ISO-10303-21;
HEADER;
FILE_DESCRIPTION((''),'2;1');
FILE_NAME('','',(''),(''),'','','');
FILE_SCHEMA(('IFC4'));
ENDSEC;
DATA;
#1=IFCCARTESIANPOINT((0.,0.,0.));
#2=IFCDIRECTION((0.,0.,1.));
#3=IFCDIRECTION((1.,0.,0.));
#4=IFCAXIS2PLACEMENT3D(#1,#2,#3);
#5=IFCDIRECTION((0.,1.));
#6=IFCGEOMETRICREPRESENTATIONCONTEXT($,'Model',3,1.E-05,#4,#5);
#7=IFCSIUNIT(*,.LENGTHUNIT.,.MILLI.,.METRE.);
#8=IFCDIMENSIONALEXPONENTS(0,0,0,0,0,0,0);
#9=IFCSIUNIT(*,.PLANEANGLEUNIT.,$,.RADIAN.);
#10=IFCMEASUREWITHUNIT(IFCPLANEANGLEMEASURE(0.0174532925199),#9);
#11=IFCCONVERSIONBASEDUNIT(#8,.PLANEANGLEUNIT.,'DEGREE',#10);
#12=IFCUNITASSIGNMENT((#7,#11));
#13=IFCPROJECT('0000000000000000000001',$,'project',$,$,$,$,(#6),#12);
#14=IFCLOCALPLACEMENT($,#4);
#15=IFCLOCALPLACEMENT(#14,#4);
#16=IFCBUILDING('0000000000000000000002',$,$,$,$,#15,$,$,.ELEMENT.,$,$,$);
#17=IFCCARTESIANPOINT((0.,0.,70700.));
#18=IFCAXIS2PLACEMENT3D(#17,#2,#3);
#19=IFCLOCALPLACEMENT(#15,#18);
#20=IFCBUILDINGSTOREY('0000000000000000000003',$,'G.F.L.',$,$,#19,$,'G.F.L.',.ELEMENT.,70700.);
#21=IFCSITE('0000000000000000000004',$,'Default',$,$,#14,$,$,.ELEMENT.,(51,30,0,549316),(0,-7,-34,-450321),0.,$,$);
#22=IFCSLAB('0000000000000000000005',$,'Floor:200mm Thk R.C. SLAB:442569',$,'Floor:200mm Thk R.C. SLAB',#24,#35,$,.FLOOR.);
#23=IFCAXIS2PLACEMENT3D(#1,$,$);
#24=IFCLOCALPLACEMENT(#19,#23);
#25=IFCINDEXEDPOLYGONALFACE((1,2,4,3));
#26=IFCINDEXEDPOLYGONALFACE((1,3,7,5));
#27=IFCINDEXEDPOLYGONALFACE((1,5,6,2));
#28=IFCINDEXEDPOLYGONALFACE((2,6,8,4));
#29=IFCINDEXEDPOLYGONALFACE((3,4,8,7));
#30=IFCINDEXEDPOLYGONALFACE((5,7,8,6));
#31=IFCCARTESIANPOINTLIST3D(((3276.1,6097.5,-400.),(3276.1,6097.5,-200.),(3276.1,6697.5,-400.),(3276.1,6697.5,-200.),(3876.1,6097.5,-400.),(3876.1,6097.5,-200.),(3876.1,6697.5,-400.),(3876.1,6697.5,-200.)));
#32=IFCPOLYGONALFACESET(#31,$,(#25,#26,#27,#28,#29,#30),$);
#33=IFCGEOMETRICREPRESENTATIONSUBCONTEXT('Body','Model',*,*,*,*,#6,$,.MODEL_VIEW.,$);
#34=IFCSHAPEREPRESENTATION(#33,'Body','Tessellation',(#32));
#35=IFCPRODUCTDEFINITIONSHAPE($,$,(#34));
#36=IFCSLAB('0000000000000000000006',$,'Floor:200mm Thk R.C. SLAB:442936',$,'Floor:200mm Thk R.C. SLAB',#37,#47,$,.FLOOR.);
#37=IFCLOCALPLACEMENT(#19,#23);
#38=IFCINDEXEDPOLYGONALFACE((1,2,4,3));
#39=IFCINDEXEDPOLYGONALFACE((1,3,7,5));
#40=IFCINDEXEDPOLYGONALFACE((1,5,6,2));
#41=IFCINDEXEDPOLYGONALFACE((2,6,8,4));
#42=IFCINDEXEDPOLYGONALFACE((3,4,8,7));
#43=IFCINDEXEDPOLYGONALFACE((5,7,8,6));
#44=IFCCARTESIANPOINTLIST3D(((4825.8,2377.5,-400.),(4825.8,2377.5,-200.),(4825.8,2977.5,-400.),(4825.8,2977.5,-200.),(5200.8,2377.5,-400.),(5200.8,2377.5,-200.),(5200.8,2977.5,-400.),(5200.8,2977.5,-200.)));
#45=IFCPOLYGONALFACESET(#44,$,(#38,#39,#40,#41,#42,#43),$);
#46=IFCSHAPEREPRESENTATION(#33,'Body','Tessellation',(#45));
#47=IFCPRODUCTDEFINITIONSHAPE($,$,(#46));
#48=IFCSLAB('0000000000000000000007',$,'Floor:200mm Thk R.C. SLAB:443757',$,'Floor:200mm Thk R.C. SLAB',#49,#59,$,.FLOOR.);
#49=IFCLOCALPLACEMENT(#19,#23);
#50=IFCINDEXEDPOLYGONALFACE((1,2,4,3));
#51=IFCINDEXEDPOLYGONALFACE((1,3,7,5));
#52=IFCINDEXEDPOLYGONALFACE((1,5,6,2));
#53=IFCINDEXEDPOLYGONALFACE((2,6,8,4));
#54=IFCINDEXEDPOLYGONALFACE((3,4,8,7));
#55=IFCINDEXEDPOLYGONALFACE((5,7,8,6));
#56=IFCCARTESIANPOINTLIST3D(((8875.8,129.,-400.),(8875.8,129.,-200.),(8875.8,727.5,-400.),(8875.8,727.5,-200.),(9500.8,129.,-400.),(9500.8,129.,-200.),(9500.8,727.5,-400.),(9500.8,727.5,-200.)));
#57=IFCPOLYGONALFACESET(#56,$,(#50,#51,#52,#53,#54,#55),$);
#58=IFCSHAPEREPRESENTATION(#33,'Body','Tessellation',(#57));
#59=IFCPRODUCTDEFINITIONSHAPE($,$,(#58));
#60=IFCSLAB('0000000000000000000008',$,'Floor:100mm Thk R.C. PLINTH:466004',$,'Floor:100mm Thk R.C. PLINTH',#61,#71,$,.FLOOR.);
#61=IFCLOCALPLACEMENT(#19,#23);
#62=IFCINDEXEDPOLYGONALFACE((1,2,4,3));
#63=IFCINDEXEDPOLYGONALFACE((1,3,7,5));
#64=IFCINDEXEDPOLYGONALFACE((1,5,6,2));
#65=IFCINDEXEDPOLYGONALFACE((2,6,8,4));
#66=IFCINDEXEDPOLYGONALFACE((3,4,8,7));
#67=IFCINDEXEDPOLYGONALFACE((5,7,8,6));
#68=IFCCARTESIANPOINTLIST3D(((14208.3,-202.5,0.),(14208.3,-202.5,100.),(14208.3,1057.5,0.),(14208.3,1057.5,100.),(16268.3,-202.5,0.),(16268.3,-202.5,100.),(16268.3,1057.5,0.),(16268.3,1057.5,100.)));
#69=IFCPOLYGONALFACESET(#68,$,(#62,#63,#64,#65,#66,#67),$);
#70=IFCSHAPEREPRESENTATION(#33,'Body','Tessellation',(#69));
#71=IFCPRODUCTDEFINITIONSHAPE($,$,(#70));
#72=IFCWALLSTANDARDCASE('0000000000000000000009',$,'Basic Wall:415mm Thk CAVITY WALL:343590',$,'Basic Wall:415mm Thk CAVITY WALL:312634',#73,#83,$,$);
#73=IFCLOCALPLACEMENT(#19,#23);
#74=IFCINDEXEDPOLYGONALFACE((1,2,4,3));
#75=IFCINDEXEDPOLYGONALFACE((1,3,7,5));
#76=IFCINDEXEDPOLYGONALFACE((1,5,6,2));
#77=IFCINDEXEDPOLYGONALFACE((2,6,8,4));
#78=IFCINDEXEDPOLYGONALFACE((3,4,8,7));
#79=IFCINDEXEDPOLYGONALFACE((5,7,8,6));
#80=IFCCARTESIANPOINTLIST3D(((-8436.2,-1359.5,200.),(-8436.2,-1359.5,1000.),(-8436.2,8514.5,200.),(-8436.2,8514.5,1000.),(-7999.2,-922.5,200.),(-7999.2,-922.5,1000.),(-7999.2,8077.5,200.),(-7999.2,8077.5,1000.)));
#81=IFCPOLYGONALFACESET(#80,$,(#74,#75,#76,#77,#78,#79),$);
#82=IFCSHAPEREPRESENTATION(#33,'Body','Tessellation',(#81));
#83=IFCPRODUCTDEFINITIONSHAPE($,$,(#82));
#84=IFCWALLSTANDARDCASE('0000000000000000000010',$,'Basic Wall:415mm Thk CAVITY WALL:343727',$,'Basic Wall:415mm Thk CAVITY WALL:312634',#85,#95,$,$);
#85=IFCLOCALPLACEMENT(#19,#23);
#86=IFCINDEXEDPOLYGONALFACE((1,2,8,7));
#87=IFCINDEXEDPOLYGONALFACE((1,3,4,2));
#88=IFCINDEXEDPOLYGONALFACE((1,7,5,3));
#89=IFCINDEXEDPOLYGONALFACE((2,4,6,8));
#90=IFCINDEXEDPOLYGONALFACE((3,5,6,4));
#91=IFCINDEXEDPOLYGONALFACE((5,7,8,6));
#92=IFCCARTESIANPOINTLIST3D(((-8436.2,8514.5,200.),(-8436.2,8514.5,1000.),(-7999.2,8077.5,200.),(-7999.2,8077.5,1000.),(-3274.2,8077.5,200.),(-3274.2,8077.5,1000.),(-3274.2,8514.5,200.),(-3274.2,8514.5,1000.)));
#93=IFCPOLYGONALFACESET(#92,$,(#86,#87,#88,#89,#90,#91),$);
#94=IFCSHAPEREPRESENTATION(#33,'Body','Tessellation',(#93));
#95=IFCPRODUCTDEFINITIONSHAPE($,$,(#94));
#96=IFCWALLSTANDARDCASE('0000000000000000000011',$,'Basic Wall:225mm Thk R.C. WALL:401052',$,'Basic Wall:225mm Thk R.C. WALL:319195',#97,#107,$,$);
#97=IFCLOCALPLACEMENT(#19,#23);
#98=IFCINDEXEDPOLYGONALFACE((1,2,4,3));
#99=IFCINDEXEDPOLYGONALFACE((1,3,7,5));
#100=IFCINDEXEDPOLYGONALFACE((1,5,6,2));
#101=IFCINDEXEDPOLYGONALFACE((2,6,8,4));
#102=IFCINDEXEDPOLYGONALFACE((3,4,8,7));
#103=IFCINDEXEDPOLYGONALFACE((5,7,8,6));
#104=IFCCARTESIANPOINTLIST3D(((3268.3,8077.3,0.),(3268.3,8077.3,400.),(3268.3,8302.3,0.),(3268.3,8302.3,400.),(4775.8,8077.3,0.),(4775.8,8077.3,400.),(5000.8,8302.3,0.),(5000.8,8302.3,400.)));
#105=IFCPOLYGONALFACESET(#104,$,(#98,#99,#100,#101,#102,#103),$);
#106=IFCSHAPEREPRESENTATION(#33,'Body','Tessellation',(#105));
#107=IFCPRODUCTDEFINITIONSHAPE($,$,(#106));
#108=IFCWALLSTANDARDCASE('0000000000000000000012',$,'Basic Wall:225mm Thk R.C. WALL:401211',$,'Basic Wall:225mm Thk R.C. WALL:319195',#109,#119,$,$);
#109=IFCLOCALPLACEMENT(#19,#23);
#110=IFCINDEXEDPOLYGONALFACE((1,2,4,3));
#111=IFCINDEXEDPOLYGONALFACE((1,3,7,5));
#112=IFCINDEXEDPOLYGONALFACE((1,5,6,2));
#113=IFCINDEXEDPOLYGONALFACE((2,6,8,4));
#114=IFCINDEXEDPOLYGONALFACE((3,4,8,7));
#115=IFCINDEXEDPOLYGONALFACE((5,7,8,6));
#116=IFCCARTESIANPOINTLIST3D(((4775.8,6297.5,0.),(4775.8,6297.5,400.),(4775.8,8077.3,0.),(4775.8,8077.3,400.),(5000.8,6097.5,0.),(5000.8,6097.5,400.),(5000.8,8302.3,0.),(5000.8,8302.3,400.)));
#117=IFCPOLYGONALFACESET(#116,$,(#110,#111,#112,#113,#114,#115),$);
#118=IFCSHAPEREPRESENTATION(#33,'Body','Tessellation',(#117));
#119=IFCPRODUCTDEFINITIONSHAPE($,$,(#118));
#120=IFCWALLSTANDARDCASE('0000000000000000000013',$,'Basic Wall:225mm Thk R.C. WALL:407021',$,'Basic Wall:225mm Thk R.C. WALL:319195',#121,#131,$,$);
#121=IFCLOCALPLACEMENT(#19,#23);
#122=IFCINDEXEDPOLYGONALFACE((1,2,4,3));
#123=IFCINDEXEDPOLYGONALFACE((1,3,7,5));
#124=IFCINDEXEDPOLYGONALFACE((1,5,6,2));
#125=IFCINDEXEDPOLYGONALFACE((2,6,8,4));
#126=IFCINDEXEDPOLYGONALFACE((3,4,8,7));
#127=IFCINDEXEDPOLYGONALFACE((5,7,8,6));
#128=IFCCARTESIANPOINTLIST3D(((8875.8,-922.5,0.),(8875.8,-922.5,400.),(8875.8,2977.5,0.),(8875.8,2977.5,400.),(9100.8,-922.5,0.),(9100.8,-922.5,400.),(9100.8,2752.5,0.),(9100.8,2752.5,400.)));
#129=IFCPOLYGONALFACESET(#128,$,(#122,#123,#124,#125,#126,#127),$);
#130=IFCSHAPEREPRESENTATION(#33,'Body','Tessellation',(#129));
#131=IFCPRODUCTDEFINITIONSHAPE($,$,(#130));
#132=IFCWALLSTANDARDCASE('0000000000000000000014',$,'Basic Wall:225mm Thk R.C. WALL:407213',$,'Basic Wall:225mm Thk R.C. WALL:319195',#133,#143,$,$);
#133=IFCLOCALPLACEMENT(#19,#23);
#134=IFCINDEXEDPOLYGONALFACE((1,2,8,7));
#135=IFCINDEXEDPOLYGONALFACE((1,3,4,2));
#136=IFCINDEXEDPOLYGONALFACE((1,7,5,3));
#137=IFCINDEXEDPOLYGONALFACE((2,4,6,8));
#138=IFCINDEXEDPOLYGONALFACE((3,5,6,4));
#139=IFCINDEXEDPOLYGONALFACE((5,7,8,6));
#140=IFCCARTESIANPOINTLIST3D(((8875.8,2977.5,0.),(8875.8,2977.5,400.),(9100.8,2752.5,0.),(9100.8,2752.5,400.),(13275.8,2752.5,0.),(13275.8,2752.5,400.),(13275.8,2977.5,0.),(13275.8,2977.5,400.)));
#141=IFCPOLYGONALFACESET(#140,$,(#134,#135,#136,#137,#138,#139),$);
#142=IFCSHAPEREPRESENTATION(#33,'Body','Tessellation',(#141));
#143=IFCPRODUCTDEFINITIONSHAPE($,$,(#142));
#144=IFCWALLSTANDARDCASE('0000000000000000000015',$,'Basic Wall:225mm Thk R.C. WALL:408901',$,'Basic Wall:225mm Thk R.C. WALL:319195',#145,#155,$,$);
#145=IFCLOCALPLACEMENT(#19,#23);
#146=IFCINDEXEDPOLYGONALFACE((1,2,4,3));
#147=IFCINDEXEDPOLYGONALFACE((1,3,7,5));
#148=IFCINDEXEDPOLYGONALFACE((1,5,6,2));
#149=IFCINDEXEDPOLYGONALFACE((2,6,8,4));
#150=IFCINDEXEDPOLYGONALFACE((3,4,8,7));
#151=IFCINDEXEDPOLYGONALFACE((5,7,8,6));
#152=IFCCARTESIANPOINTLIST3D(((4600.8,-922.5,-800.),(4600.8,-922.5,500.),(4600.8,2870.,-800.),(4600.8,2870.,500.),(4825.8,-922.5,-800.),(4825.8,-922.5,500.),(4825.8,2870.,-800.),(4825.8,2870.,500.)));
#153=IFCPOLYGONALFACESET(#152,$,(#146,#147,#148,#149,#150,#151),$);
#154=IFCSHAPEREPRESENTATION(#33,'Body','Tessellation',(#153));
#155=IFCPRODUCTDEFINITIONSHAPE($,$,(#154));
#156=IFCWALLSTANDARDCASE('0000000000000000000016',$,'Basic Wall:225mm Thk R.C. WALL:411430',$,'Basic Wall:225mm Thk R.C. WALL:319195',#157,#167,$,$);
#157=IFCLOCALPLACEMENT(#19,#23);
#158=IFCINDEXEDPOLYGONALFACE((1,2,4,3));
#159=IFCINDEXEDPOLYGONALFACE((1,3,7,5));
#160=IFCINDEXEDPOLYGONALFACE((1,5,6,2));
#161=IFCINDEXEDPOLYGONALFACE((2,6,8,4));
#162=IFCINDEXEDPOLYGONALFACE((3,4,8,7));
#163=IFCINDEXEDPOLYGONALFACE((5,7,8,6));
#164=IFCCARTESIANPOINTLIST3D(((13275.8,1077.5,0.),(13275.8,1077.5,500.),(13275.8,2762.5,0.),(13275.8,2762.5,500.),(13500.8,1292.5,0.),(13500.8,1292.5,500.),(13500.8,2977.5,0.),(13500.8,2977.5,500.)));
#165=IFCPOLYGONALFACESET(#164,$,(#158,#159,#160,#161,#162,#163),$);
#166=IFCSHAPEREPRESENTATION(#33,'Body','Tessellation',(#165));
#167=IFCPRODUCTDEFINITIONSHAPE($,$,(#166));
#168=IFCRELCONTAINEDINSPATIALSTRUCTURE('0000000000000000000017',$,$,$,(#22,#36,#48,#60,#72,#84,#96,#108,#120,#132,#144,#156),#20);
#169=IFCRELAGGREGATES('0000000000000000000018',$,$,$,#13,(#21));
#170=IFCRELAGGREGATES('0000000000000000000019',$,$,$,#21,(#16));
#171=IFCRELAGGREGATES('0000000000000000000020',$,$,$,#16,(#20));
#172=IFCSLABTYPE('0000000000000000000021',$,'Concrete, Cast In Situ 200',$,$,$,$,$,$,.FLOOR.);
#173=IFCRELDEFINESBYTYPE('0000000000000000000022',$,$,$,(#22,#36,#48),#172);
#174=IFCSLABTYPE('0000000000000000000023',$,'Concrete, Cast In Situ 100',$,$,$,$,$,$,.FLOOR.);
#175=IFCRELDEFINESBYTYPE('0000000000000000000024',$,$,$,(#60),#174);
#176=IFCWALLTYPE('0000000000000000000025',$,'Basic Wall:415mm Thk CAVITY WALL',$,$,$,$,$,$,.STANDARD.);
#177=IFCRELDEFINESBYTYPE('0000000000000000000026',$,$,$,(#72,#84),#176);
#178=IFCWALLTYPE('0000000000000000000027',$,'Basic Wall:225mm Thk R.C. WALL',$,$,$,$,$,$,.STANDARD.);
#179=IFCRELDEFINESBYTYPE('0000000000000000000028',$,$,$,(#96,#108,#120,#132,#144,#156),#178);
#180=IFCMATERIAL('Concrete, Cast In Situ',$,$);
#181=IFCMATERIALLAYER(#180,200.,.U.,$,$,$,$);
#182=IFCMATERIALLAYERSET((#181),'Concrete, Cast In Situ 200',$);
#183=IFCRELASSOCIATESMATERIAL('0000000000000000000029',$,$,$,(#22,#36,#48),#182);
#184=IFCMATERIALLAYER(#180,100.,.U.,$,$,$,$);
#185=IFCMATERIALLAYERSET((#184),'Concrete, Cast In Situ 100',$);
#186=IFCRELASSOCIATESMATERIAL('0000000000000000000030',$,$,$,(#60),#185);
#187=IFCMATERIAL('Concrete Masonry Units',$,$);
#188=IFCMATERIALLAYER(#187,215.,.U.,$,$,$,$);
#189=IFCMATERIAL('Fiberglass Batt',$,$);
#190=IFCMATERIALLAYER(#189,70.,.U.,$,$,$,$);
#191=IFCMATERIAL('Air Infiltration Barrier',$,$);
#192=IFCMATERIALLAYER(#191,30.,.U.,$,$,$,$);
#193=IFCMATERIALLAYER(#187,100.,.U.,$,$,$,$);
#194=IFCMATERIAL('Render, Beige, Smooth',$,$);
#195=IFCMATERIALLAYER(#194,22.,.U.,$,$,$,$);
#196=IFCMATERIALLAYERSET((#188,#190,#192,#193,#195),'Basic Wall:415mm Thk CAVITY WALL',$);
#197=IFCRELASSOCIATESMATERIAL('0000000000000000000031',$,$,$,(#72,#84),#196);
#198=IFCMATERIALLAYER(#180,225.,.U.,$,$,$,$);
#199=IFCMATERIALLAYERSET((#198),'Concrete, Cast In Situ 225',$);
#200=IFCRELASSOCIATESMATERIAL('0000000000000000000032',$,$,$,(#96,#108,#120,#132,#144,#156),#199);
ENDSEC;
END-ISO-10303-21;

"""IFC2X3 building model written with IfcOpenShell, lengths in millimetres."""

from ifc_helpers import new_model, entity, si_unit, converted_unit, direction, frame, origin_with_axes, place, context, subcontext, project, spatial, polyline, outline, extrude, material, layer, layer_set, layer_usage, type_object, element, save


model = new_model("IFC2X3")

# Units and contexts
model_context = context("Model", 3, precision=1e-05, world=origin_with_axes(), true_north=direction((0.0, 1.0)))
body_context = subcontext(model_context, "Body", "Model", "MODEL_VIEW")
ifc_project = project(units=[si_unit("LENGTHUNIT", "METRE", prefix="MILLI"), converted_unit("PLANEANGLEUNIT", "DEGREE", entity("IfcPlaneAngleMeasure", 0.0174532925199), si_unit("PLANEANGLEUNIT", "RADIAN"), dimensions=[0, 0, 0, 0, 0, 0, 0])], contexts=[model_context])

# Site, building, storey
site_placement = place(None, origin_with_axes())
site = spatial("IfcSite", under=ifc_project, at=site_placement, Name="Default", CompositionType="ELEMENT", RefLatitude=(51, 30, 0, 549316), RefLongitude=(0, -7, -34, -450321), RefElevation=0.0)
building_placement = place(site_placement, origin_with_axes())
building = spatial("IfcBuilding", under=site, at=building_placement, CompositionType="ELEMENT")
storey_placement = place(building_placement, frame((0.0, 0.0, 70700.0), z_axis=(0.0, 0.0, 1.0), x_axis=(1.0, 0.0, 0.0)))
storey = spatial("IfcBuildingStorey", under=building, at=storey_placement, Name="G.F.L.", LongName="G.F.L.", CompositionType="ELEMENT", Elevation=70700.0)

# Slabs
ifc_material_1 = material(Name="Concrete, Cast In Situ")
ifc_layer_1 = layer(ifc_material_1, 200.0, ventilated="UNKNOWN")
ifc_layer_set_1 = layer_set([ifc_layer_1], Name="Concrete, Cast In Situ 200")
ifc_layer_usage_1 = layer_usage(ifc_layer_set_1, "AXIS3", "NEGATIVE", 200.0)
slab_type_1 = type_object("IfcSlabType", Name="Concrete, Cast In Situ 200", PredefinedType="FLOOR")
slab_1_placement = place(storey_placement, frame((3276.1, 6697.5, -200.0), z_axis=(0.0, 0.0, 1.0), x_axis=(1.0, 0.0, 0.0)))
element("IfcSlab", 1, at=slab_1_placement, inside=storey, type_object=slab_type_1, material=ifc_layer_usage_1, Name="Floor:200mm Thk R.C. SLAB:442569", ObjectType="Floor:200mm Thk R.C. SLAB", PredefinedType="FLOOR", context=body_context, shape_type="SweptSolid", body=[
    extrude(outline(polyline([(0.0, 0.0), (0.0, -600.0), (600.0, -600.0), (600.0, 0.0), (0.0, 0.0)])), frame((0.0, 0.0, -200.0), z_axis=(0.0, 0.0, 1.0), x_axis=(1.0, 0.0, 0.0)), (0.0, 0.0, 1.0), 200.0),
])
ifc_layer_usage_2 = layer_usage(ifc_layer_set_1, "AXIS3", "NEGATIVE", 200.0)
slab_2_placement = place(storey_placement, frame((4825.8, 2977.5, -200.0), z_axis=(0.0, 0.0, 1.0), x_axis=(1.0, 0.0, 0.0)))
element("IfcSlab", 2, at=slab_2_placement, inside=storey, type_object=slab_type_1, material=ifc_layer_usage_2, Name="Floor:200mm Thk R.C. SLAB:442936", ObjectType="Floor:200mm Thk R.C. SLAB", PredefinedType="FLOOR", context=body_context, shape_type="SweptSolid", body=[
    extrude(outline(polyline([(0.0, 0.0), (0.0, -600.0), (375.0, -600.0), (375.0, 0.0), (0.0, 0.0)])), frame((0.0, 0.0, -200.0), z_axis=(0.0, 0.0, 1.0), x_axis=(1.0, 0.0, 0.0)), (0.0, 0.0, 1.0), 200.0),
])
ifc_layer_usage_3 = layer_usage(ifc_layer_set_1, "AXIS3", "NEGATIVE", 200.0)
slab_3_placement = place(storey_placement, frame((8875.8, 727.5, -200.0), z_axis=(0.0, 0.0, 1.0), x_axis=(1.0, 0.0, 0.0)))
element("IfcSlab", 3, at=slab_3_placement, inside=storey, type_object=slab_type_1, material=ifc_layer_usage_3, Name="Floor:200mm Thk R.C. SLAB:443757", ObjectType="Floor:200mm Thk R.C. SLAB", PredefinedType="FLOOR", context=body_context, shape_type="SweptSolid", body=[
    extrude(outline(polyline([(0.0, 0.0), (0.0, -598.5), (625.0, -598.5), (625.0, 0.0), (0.0, 0.0)])), frame((0.0, 0.0, -200.0), z_axis=(0.0, 0.0, 1.0), x_axis=(1.0, 0.0, 0.0)), (0.0, 0.0, 1.0), 200.0),
])
ifc_layer_2 = layer(ifc_material_1, 100.0, ventilated="UNKNOWN")
ifc_layer_set_2 = layer_set([ifc_layer_2], Name="Concrete, Cast In Situ 100")
ifc_layer_usage_4 = layer_usage(ifc_layer_set_2, "AXIS3", "NEGATIVE", 100.0)
slab_type_2 = type_object("IfcSlabType", Name="Concrete, Cast In Situ 100", PredefinedType="FLOOR")
slab_4_placement = place(storey_placement, frame((14208.3, 1057.5, 0.0), z_axis=(0.0, 0.0, 1.0), x_axis=(1.0, 0.0, 0.0)))
element("IfcSlab", 4, at=slab_4_placement, inside=storey, type_object=slab_type_2, material=ifc_layer_usage_4, Name="Floor:100mm Thk R.C. PLINTH:466004", ObjectType="Floor:100mm Thk R.C. PLINTH", PredefinedType="FLOOR", context=body_context, shape_type="SweptSolid", body=[
    extrude(outline(polyline([(0.0, 0.0), (0.0, -1260.0), (2060.0, -1260.0), (2060.0, 0.0), (0.0, 0.0)])), origin_with_axes(), (0.0, 0.0, 1.0), 100.0),
])

# Shared definitions
ifc_material_2 = material(Name="Concrete Masonry Units")
ifc_layer_3 = layer(ifc_material_2, 215.0, ventilated="UNKNOWN")
ifc_material_3 = material(Name="Fiberglass Batt")
ifc_layer_4 = layer(ifc_material_3, 70.0, ventilated="UNKNOWN")
ifc_material_4 = material(Name="Air Infiltration Barrier")
ifc_layer_5 = layer(ifc_material_4, 30.0, ventilated="UNKNOWN")
ifc_layer_6 = layer(ifc_material_2, 100.0, ventilated="UNKNOWN")
ifc_material_5 = material(Name="Render, Beige, Smooth")
ifc_layer_7 = layer(ifc_material_5, 22.0, ventilated="UNKNOWN")
ifc_layer_set_3 = layer_set([ifc_layer_3, ifc_layer_4, ifc_layer_5, ifc_layer_6, ifc_layer_7], Name="Basic Wall:415mm Thk CAVITY WALL")
wall_type_1 = type_object("IfcWallType", Name="Basic Wall:415mm Thk CAVITY WALL", PredefinedType="STANDARD")

# Walls
ifc_layer_usage_5 = layer_usage(ifc_layer_set_3, "AXIS2", "POSITIVE", -218.5)
wall_1_placement = place(storey_placement, frame((-8217.7, -1141.0, 200.0), z_axis=(0.0, 0.0, 1.0), x_axis=(0.0, 1.0, 0.0)))
element("IfcWallStandardCase", 5, at=wall_1_placement, inside=storey, type_object=wall_type_1, material=ifc_layer_usage_5, Name="Basic Wall:415mm Thk CAVITY WALL:343590", ObjectType="Basic Wall:415mm Thk CAVITY WALL:312634", context=body_context, shape_type="SweptSolid", body=[
    extrude(outline(polyline([(218.5, -218.5), (9218.5, -218.5), (9655.5, 218.5), (-218.5, 218.5), (218.5, -218.5)])), origin_with_axes(), (0.0, 0.0, 1.0), 800.0),
])
ifc_layer_usage_6 = layer_usage(ifc_layer_set_3, "AXIS2", "POSITIVE", -218.5)
wall_2_placement = place(storey_placement, frame((-8217.7, 8296.0, 200.0), z_axis=(0.0, 0.0, 1.0), x_axis=(1.0, 0.0, 0.0)))
element("IfcWallStandardCase", 6, at=wall_2_placement, inside=storey, type_object=wall_type_1, material=ifc_layer_usage_6, Name="Basic Wall:415mm Thk CAVITY WALL:343727", ObjectType="Basic Wall:415mm Thk CAVITY WALL:312634", context=body_context, shape_type="SweptSolid", body=[
    extrude(outline(polyline([(218.5, -218.5), (4943.5, -218.5), (4943.5, 218.5), (-218.5, 218.5), (218.5, -218.5)])), origin_with_axes(), (0.0, 0.0, 1.0), 800.0),
])
ifc_layer_8 = layer(ifc_material_1, 225.0, ventilated="UNKNOWN")
ifc_layer_set_4 = layer_set([ifc_layer_8], Name="Concrete, Cast In Situ 225")
ifc_layer_usage_7 = layer_usage(ifc_layer_set_4, "AXIS2", "POSITIVE", -112.5)
wall_type_2 = type_object("IfcWallType", Name="Basic Wall:225mm Thk R.C. WALL", PredefinedType="STANDARD")
wall_3_placement = place(storey_placement, frame((3268.3, 8189.8, 0.0), z_axis=(0.0, 0.0, 1.0), x_axis=(1.0, 0.0, 0.0)))
element("IfcWallStandardCase", 7, at=wall_3_placement, inside=storey, type_object=wall_type_2, material=ifc_layer_usage_7, Name="Basic Wall:225mm Thk R.C. WALL:401052", ObjectType="Basic Wall:225mm Thk R.C. WALL:319195", context=body_context, shape_type="SweptSolid", body=[
    extrude(outline(polyline([(0.0, -112.5), (1507.5, -112.5), (1732.5, 112.5), (0.0, 112.5), (0.0, -112.5)])), origin_with_axes(), (0.0, 0.0, 1.0), 400.0),
])
ifc_layer_usage_8 = layer_usage(ifc_layer_set_4, "AXIS2", "POSITIVE", -112.5)
wall_4_placement = place(storey_placement, frame((4888.3, 8189.8, 0.0), z_axis=(0.0, 0.0, 1.0), x_axis=(0.0, -1.0, 0.0)))
element("IfcWallStandardCase", 8, at=wall_4_placement, inside=storey, type_object=wall_type_2, material=ifc_layer_usage_8, Name="Basic Wall:225mm Thk R.C. WALL:401211", ObjectType="Basic Wall:225mm Thk R.C. WALL:319195", context=body_context, shape_type="SweptSolid", body=[
    extrude(outline(polyline([(112.5, -112.5), (1892.2, -112.5), (2092.2, 112.5), (-112.5, 112.5), (112.5, -112.5)])), origin_with_axes(), (0.0, 0.0, 1.0), 400.0),
])
ifc_layer_usage_9 = layer_usage(ifc_layer_set_4, "AXIS2", "POSITIVE", -112.5)
wall_5_placement = place(storey_placement, frame((8988.3, 2865.0, 0.0), z_axis=(0.0, 0.0, 1.0), x_axis=(0.0, -1.0, 0.0)))
element("IfcWallStandardCase", 9, at=wall_5_placement, inside=storey, type_object=wall_type_2, material=ifc_layer_usage_9, Name="Basic Wall:225mm Thk R.C. WALL:407021", ObjectType="Basic Wall:225mm Thk R.C. WALL:319195", context=body_context, shape_type="SweptSolid", body=[
    extrude(outline(polyline([(-112.5, -112.5), (3787.5, -112.5), (3787.5, 112.5), (112.5, 112.5), (-112.5, -112.5)])), origin_with_axes(), (0.0, 0.0, 1.0), 400.0),
])
ifc_layer_usage_10 = layer_usage(ifc_layer_set_4, "AXIS2", "POSITIVE", -112.5)
wall_6_placement = place(storey_placement, frame((8988.3, 2865.0, 0.0), z_axis=(0.0, 0.0, 1.0), x_axis=(1.0, 0.0, 0.0)))
element("IfcWallStandardCase", 10, at=wall_6_placement, inside=storey, type_object=wall_type_2, material=ifc_layer_usage_10, Name="Basic Wall:225mm Thk R.C. WALL:407213", ObjectType="Basic Wall:225mm Thk R.C. WALL:319195", context=body_context, shape_type="SweptSolid", body=[
    extrude(outline(polyline([(112.5, -112.5), (4287.5, -112.5), (4287.5, 112.5), (-112.5, 112.5), (112.5, -112.5)])), origin_with_axes(), (0.0, 0.0, 1.0), 400.0),
])
ifc_layer_usage_11 = layer_usage(ifc_layer_set_4, "AXIS2", "POSITIVE", -112.5)
wall_7_placement = place(storey_placement, frame((4713.3, 2870.0, -800.0), z_axis=(0.0, 0.0, 1.0), x_axis=(0.0, -1.0, 0.0)))
element("IfcWallStandardCase", 11, at=wall_7_placement, inside=storey, type_object=wall_type_2, material=ifc_layer_usage_11, Name="Basic Wall:225mm Thk R.C. WALL:408901", ObjectType="Basic Wall:225mm Thk R.C. WALL:319195", context=body_context, shape_type="SweptSolid", body=[
    extrude(outline(polyline([(0.0, -112.5), (3792.5, -112.5), (3792.5, 112.5), (0.0, 112.5), (0.0, -112.5)])), origin_with_axes(), (0.0, 0.0, 1.0), 1300.0),
])
ifc_layer_usage_12 = layer_usage(ifc_layer_set_4, "AXIS2", "POSITIVE", -112.5)
wall_8_placement = place(storey_placement, frame((13388.3, 2870.0, 0.0), z_axis=(0.0, 0.0, 1.0), x_axis=(0.0, -1.0, 0.0)))
element("IfcWallStandardCase", 12, at=wall_8_placement, inside=storey, type_object=wall_type_2, material=ifc_layer_usage_12, Name="Basic Wall:225mm Thk R.C. WALL:411430", ObjectType="Basic Wall:225mm Thk R.C. WALL:319195", context=body_context, shape_type="SweptSolid", body=[
    extrude(outline(polyline([(107.5, -112.5), (1792.5, -112.5), (1577.5, 112.5), (-107.5, 112.5), (107.5, -112.5)])), origin_with_axes(), (0.0, 0.0, 1.0), 500.0),
])

save(model, "model.ifc")
